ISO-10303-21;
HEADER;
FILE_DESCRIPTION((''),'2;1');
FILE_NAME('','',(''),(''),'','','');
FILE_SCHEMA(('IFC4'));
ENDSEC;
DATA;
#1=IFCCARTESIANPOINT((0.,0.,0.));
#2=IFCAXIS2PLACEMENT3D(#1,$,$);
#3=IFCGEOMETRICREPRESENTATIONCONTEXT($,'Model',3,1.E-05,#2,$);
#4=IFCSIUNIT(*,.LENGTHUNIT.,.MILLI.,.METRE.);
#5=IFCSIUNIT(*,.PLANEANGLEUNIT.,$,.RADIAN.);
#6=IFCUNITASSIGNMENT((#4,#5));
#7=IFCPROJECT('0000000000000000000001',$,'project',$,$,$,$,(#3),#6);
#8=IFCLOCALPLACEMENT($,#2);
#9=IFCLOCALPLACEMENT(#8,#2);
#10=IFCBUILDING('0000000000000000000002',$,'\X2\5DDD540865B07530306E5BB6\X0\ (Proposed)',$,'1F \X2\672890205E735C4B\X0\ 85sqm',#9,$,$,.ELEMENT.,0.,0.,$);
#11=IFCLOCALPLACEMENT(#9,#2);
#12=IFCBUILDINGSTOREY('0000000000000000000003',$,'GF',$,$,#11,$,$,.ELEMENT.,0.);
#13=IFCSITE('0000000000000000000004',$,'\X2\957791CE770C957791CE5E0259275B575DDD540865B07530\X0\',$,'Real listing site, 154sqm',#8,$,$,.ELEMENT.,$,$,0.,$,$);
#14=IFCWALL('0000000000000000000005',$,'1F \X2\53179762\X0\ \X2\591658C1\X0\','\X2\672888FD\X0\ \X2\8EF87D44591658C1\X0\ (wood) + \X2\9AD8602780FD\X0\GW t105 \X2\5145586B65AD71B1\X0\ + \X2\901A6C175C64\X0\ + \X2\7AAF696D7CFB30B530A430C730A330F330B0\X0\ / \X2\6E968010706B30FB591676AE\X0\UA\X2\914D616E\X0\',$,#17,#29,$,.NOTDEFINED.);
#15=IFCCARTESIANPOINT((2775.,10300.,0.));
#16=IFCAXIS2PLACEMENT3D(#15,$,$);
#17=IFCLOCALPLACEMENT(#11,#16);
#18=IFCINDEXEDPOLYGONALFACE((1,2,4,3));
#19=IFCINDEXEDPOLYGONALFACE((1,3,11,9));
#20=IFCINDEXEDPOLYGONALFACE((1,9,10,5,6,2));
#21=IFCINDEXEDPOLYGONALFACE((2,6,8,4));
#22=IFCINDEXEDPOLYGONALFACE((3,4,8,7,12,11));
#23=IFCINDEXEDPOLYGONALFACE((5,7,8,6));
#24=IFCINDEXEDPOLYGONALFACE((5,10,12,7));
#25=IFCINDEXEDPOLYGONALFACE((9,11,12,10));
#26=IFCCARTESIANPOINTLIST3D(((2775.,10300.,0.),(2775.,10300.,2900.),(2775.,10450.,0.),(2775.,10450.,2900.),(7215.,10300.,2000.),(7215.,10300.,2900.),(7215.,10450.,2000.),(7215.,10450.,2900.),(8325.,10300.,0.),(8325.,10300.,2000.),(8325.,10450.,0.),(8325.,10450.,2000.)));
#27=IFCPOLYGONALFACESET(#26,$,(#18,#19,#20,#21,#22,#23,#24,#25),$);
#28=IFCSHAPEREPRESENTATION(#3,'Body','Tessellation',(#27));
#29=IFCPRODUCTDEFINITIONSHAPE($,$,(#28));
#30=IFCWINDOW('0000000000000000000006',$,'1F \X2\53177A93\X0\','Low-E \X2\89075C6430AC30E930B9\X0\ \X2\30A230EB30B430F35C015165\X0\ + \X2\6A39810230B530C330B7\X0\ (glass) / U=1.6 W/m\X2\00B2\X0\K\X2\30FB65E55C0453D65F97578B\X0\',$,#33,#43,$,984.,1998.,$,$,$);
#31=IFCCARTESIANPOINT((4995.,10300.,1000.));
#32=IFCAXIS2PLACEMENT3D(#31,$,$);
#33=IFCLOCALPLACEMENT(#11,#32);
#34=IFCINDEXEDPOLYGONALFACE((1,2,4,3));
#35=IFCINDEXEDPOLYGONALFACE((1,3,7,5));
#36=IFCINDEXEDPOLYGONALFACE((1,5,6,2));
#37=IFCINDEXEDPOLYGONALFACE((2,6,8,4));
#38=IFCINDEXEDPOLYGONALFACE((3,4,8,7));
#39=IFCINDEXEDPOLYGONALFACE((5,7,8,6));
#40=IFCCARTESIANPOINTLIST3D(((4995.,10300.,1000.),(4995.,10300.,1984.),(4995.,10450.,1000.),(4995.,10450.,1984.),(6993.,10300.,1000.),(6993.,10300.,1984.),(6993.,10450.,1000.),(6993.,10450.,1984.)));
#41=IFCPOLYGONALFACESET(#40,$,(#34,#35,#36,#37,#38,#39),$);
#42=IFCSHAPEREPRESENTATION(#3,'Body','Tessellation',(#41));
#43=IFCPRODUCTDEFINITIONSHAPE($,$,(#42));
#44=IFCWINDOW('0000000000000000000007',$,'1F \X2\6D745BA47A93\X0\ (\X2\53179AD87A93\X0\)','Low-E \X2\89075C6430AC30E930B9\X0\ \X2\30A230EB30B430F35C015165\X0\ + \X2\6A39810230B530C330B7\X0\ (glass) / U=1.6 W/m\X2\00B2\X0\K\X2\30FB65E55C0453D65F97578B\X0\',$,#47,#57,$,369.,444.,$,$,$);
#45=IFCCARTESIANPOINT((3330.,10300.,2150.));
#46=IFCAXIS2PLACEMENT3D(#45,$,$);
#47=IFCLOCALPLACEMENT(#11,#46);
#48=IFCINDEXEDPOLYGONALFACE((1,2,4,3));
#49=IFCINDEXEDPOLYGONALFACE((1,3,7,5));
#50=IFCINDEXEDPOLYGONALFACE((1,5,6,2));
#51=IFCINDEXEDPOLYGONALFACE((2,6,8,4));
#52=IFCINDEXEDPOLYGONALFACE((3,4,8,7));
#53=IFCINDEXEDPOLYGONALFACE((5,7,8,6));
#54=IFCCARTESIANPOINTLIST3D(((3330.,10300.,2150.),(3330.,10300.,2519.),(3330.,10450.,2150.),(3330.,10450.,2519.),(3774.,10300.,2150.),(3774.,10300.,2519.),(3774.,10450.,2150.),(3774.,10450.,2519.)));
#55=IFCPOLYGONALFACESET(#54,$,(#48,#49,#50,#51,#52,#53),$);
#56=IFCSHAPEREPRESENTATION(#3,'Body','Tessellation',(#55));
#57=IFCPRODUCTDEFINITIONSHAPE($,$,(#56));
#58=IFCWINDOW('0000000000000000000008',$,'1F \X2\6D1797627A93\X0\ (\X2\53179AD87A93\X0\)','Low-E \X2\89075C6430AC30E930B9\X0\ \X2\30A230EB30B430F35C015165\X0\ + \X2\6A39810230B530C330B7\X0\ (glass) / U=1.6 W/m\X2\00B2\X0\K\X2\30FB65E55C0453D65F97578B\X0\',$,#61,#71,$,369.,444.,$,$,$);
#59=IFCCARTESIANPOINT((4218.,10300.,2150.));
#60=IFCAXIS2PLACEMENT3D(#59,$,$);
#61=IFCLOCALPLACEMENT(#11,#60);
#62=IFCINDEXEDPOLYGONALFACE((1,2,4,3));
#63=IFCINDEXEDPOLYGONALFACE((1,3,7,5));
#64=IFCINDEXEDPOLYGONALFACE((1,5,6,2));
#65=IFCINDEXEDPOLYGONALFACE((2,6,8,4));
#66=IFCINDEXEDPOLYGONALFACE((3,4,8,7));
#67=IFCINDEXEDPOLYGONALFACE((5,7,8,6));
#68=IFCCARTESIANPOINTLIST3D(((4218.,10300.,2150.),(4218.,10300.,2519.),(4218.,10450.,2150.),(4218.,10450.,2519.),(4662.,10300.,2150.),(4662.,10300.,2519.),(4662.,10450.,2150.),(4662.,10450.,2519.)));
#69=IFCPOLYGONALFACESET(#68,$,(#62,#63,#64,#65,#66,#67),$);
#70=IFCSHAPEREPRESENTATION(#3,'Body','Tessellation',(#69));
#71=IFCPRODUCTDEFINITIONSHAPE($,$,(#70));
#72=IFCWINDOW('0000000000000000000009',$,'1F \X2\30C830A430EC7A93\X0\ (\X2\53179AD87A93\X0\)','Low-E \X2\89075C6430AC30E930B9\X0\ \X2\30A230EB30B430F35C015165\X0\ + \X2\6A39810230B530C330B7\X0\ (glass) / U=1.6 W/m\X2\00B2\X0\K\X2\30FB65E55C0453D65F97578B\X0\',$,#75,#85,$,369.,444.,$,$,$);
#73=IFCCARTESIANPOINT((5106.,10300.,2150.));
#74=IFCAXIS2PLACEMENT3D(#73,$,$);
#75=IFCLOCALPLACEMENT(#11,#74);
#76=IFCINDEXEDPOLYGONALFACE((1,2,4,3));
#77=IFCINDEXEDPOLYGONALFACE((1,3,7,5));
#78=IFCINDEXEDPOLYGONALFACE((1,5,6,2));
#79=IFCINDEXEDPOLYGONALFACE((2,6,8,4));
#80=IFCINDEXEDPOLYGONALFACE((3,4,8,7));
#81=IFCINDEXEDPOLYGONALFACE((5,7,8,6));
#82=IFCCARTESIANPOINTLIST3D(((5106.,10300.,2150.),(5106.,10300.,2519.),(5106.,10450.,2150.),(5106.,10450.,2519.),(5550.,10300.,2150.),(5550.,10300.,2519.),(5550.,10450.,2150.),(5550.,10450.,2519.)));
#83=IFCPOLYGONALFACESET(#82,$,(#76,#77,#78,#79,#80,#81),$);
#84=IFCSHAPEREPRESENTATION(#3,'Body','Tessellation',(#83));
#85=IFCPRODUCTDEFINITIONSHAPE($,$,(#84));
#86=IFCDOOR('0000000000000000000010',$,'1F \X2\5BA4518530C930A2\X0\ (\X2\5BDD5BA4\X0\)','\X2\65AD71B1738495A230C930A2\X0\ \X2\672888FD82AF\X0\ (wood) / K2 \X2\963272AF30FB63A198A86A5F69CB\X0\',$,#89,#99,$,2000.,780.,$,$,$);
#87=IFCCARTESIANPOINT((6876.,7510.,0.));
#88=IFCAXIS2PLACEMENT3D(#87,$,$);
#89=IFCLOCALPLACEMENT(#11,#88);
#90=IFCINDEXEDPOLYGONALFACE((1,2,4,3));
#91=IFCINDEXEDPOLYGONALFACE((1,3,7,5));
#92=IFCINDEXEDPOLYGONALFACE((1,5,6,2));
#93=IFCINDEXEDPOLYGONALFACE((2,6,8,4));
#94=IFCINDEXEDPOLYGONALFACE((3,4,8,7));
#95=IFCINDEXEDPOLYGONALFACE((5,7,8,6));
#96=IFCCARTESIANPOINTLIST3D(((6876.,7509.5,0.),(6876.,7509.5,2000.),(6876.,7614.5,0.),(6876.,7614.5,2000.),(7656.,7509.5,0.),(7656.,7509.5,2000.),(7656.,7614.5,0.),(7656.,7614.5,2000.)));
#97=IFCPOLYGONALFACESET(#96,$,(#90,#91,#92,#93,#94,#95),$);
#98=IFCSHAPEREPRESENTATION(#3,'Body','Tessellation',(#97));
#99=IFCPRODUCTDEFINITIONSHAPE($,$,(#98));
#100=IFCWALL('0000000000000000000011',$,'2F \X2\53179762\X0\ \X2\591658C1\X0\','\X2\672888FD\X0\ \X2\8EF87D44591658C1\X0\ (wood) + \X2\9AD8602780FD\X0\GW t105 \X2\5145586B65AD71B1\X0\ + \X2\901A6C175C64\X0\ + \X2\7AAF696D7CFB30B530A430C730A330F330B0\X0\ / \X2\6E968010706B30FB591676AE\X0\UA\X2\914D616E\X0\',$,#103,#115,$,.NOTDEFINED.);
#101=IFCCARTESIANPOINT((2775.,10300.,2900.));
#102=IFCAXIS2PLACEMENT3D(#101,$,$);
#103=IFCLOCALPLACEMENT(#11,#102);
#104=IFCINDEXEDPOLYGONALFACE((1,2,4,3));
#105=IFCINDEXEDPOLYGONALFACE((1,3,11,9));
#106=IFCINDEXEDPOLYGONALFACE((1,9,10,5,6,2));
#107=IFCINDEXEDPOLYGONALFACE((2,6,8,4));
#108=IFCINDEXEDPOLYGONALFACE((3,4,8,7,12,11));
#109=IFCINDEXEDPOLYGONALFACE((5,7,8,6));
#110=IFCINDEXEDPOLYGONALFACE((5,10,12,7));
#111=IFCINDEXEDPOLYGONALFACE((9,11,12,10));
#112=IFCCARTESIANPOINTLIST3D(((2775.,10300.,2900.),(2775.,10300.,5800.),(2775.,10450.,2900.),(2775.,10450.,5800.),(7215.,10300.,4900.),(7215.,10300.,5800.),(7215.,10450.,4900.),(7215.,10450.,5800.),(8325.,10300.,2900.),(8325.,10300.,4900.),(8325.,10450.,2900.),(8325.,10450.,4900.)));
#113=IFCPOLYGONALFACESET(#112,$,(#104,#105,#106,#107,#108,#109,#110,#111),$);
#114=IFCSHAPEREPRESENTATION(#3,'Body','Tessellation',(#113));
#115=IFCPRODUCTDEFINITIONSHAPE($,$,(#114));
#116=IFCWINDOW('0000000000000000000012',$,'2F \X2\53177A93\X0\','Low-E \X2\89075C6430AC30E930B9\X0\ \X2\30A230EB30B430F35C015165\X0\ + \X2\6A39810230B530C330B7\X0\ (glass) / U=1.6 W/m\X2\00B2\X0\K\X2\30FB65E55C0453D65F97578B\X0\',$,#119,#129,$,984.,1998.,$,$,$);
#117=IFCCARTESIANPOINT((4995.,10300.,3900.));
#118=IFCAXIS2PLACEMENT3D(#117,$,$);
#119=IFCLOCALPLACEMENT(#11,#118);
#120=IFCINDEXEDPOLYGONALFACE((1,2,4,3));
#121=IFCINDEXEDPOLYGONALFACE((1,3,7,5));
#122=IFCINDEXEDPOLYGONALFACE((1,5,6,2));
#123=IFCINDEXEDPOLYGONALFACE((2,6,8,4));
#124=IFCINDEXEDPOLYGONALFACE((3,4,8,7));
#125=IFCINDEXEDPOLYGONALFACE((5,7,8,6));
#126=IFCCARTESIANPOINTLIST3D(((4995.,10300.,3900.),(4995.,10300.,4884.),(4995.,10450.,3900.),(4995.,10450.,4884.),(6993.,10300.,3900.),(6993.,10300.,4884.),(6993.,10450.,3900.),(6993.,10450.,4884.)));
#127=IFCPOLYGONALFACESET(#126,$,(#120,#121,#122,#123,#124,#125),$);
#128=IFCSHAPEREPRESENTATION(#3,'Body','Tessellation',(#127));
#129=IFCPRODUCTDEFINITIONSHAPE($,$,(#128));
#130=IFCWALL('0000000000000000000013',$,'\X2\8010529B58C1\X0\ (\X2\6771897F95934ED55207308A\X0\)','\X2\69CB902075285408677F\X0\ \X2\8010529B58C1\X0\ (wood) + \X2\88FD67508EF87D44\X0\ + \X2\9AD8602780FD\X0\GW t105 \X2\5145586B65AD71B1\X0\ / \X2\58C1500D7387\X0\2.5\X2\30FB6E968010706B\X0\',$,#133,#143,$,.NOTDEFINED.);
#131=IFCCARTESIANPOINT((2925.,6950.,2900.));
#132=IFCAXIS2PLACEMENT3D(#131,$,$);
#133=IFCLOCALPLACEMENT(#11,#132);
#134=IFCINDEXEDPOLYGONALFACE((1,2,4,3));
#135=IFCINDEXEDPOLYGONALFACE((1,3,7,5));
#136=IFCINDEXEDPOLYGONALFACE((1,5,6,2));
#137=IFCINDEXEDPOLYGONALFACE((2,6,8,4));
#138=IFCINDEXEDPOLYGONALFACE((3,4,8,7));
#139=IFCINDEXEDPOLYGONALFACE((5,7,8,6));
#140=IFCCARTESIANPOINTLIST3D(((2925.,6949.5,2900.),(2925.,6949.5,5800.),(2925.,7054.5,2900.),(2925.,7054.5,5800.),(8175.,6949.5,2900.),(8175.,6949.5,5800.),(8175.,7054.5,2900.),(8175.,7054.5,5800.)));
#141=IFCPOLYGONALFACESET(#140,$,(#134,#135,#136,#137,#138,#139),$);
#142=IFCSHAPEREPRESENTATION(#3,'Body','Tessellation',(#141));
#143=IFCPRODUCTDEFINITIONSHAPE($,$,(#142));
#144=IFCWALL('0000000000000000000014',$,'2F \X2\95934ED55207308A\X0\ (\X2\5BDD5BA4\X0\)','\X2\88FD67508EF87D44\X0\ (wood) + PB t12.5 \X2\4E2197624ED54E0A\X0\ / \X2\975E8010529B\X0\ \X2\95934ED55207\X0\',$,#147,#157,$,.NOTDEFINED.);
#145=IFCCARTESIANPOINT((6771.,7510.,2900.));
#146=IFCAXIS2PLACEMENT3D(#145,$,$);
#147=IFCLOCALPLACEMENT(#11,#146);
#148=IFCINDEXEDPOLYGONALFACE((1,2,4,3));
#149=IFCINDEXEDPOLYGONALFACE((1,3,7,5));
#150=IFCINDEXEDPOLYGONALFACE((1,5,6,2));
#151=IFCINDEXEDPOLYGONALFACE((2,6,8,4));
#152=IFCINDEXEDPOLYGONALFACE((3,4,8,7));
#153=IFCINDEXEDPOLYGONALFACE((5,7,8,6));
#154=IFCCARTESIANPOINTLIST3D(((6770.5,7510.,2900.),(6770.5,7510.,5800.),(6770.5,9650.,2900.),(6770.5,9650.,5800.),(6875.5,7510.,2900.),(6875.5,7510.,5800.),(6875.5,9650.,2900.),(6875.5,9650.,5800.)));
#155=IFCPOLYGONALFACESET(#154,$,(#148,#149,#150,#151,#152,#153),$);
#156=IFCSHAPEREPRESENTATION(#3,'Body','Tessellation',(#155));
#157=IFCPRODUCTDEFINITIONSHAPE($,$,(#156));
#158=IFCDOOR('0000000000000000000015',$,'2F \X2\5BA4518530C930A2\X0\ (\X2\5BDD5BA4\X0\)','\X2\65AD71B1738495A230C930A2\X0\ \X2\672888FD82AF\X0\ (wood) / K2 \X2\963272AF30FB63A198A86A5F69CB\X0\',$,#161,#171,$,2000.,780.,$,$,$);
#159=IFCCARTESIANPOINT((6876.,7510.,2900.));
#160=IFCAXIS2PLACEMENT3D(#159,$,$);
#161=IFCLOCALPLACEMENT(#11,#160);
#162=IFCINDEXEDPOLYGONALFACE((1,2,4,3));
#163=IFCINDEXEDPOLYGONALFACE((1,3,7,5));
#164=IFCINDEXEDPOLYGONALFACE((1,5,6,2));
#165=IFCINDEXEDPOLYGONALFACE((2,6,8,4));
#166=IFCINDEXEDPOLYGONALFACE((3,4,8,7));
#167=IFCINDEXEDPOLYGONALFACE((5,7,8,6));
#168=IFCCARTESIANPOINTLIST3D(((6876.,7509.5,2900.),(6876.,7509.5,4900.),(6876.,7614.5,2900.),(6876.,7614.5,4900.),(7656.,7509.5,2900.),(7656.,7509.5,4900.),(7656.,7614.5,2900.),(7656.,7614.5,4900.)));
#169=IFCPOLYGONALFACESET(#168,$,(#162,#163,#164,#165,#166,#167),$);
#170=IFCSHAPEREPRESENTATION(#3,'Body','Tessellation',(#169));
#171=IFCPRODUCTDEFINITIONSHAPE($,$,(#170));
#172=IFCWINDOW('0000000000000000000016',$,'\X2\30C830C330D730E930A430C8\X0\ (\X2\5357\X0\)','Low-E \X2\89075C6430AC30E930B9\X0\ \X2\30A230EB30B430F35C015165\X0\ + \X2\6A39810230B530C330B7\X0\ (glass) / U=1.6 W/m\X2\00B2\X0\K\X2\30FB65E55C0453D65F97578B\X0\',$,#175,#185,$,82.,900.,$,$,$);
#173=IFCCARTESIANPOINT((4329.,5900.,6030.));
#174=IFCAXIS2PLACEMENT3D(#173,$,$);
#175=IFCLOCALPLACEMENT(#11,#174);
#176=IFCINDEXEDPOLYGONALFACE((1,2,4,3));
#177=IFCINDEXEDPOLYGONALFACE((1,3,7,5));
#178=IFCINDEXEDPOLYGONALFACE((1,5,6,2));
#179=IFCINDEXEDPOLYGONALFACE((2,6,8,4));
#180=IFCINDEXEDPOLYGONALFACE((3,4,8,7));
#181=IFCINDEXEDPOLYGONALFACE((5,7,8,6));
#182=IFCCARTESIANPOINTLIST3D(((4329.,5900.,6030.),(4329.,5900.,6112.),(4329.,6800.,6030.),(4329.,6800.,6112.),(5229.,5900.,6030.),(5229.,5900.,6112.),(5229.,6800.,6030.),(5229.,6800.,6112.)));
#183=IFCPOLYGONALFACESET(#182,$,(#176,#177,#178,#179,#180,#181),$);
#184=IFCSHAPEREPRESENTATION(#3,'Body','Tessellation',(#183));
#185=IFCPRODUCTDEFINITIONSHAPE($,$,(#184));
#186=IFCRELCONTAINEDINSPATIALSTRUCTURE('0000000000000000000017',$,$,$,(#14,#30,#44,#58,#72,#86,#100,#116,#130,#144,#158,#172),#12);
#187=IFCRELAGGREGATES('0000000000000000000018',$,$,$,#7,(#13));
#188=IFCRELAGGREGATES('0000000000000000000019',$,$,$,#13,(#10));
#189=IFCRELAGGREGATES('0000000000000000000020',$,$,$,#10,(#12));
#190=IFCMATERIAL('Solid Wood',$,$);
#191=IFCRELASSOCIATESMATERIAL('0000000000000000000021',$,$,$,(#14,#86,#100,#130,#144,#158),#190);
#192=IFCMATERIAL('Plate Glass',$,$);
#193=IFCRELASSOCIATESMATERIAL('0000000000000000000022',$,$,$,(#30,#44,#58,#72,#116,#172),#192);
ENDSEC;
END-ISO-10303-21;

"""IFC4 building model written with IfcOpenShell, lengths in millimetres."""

from ifc_helpers import new_model, si_unit, frame, frame_2d, origin, place, context, project, spatial, rectangle, extrude, material, element, fill, save


model = new_model("IFC4")

# Units and contexts
model_context = context("Model", 3, precision=1e-05, world=origin())
ifc_project = project(units=[si_unit("LENGTHUNIT", "METRE", prefix="MILLI"), si_unit("PLANEANGLEUNIT", "RADIAN")], contexts=[model_context])

# Site, building, storey
site_placement = place(None, origin())
site = spatial("IfcSite", under=ifc_project, at=site_placement, Name="長野県長野市大字川合新田", ObjectType="Real listing site, 154sqm", CompositionType="ELEMENT", RefElevation=0.0)
building_placement = place(site_placement, origin())
building = spatial("IfcBuilding", under=site, at=building_placement, Name="川合新田の家 (Proposed)", ObjectType="1F 木造平屋 85sqm", CompositionType="ELEMENT", ElevationOfRefHeight=0.0, ElevationOfTerrain=0.0)
storey_placement = place(building_placement, origin())
storey = spatial("IfcBuildingStorey", under=building, at=storey_placement, Name="GF", CompositionType="ELEMENT", Elevation=0.0)

# Wall, openings, windows
ifc_material_1 = material(Name="Solid Wood")
wall_1_placement = place(storey_placement, frame((2775.0, 10300.0, 0.0)))
wall_1 = element("IfcWall", 1, at=wall_1_placement, inside=storey, material=ifc_material_1, Name="1F 北面 外壁", Description="木製 軸組外壁 (wood) + 高性能GW t105 充填断熱 + 通気層 + 窯業系サイディング / 準耐火・外皮UA配慮", PredefinedType="NOTDEFINED", context=model_context, shape_type="SweptSolid", body=[
    extrude(rectangle(XDim=5550.0, YDim=150.0, at=frame_2d((2775.0, 75.0))), frame((2775.0, 10300.0, 0.0)), (0.0, 0.0, 1.0), 2900.0),
])
opening_1_placement = place(storey_placement, frame((4995.0, 10300.0, 1000.0)))
opening_1 = element("IfcOpeningElement", 2, at=opening_1_placement, cuts=wall_1, PredefinedType="NOTDEFINED", context=model_context, shape_type="SweptSolid", body=[
    extrude(rectangle(XDim=1998.0, YDim=150.0, at=frame_2d((999.0, 75.0))), frame((4995.0, 10300.0, 1000.0)), (0.0, 0.0, 1.0), 984.0),
])
opening_2_placement = place(storey_placement, frame((3330.0, 10300.0, 2150.0)))
opening_2 = element("IfcOpeningElement", 3, at=opening_2_placement, cuts=wall_1, PredefinedType="NOTDEFINED", context=model_context, shape_type="SweptSolid", body=[
    extrude(rectangle(XDim=444.0, YDim=150.0, at=frame_2d((222.0, 75.0))), frame((3330.0, 10300.0, 2150.0)), (0.0, 0.0, 1.0), 369.0),
])
opening_3_placement = place(storey_placement, frame((4218.0, 10300.0, 2150.0)))
opening_3 = element("IfcOpeningElement", 4, at=opening_3_placement, cuts=wall_1, PredefinedType="NOTDEFINED", context=model_context, shape_type="SweptSolid", body=[
    extrude(rectangle(XDim=444.0, YDim=150.0, at=frame_2d((222.0, 75.0))), frame((4218.0, 10300.0, 2150.0)), (0.0, 0.0, 1.0), 369.0),
])
opening_4_placement = place(storey_placement, frame((5106.0, 10300.0, 2150.0)))
opening_4 = element("IfcOpeningElement", 5, at=opening_4_placement, cuts=wall_1, PredefinedType="NOTDEFINED", context=model_context, shape_type="SweptSolid", body=[
    extrude(rectangle(XDim=444.0, YDim=150.0, at=frame_2d((222.0, 75.0))), frame((5106.0, 10300.0, 2150.0)), (0.0, 0.0, 1.0), 369.0),
])
ifc_material_2 = material(Name="Plate Glass")
window_1_placement = place(storey_placement, frame((4995.0, 10300.0, 1000.0)))
window_1 = element("IfcWindow", 6, at=window_1_placement, inside=storey, material=ifc_material_2, Name="1F 北窓", Description="Low-E 複層ガラス アルゴン封入 + 樹脂サッシ (glass) / U=1.6 W/m²K・日射取得型", OverallHeight=984.0, OverallWidth=1998.0, context=model_context, shape_type="SweptSolid", body=[
    extrude(rectangle(XDim=1998.0, YDim=150.0, at=frame_2d((999.0, 75.0))), frame((4995.0, 10300.0, 1000.0)), (0.0, 0.0, 1.0), 984.0),
])
fill(opening_1, window_1)
window_2_placement = place(storey_placement, frame((3330.0, 10300.0, 2150.0)))
window_2 = element("IfcWindow", 7, at=window_2_placement, inside=storey, material=ifc_material_2, Name="1F 浴室窓 (北高窓)", Description="Low-E 複層ガラス アルゴン封入 + 樹脂サッシ (glass) / U=1.6 W/m²K・日射取得型", OverallHeight=369.0, OverallWidth=444.0, context=model_context, shape_type="SweptSolid", body=[
    extrude(rectangle(XDim=444.0, YDim=150.0, at=frame_2d((222.0, 75.0))), frame((3330.0, 10300.0, 2150.0)), (0.0, 0.0, 1.0), 369.0),
])
fill(opening_2, window_2)
window_3_placement = place(storey_placement, frame((4218.0, 10300.0, 2150.0)))
window_3 = element("IfcWindow", 8, at=window_3_placement, inside=storey, material=ifc_material_2, Name="1F 洗面窓 (北高窓)", Description="Low-E 複層ガラス アルゴン封入 + 樹脂サッシ (glass) / U=1.6 W/m²K・日射取得型", OverallHeight=369.0, OverallWidth=444.0, context=model_context, shape_type="SweptSolid", body=[
    extrude(rectangle(XDim=444.0, YDim=150.0, at=frame_2d((222.0, 75.0))), frame((4218.0, 10300.0, 2150.0)), (0.0, 0.0, 1.0), 369.0),
])
fill(opening_3, window_3)
window_4_placement = place(storey_placement, frame((5106.0, 10300.0, 2150.0)))
window_4 = element("IfcWindow", 9, at=window_4_placement, inside=storey, material=ifc_material_2, Name="1F トイレ窓 (北高窓)", Description="Low-E 複層ガラス アルゴン封入 + 樹脂サッシ (glass) / U=1.6 W/m²K・日射取得型", OverallHeight=369.0, OverallWidth=444.0, context=model_context, shape_type="SweptSolid", body=[
    extrude(rectangle(XDim=444.0, YDim=150.0, at=frame_2d((222.0, 75.0))), frame((5106.0, 10300.0, 2150.0)), (0.0, 0.0, 1.0), 369.0),
])
fill(opening_4, window_4)

# Door
door_1_placement = place(storey_placement, frame((6876.0, 7510.0, 0.0)))
element("IfcDoor", 10, at=door_1_placement, inside=storey, material=ifc_material_1, Name="1F 室内ドア (寝室)", Description="断熱玄関ドア 木製芯 (wood) / K2 防犯・採風機構", OverallHeight=2000.0, OverallWidth=780.0, context=model_context, shape_type="SweptSolid", body=[
    extrude(rectangle(XDim=780.0, YDim=105.0, at=frame_2d((390.0, 52.0))), frame((6876.0, 7510.0, 0.0)), (0.0, 0.0, 1.0), 2000.0),
])

# Wall, opening, window
wall_2_placement = place(storey_placement, frame((2775.0, 10300.0, 2900.0)))
wall_2 = element("IfcWall", 11, at=wall_2_placement, inside=storey, material=ifc_material_1, Name="2F 北面 外壁", Description="木製 軸組外壁 (wood) + 高性能GW t105 充填断熱 + 通気層 + 窯業系サイディング / 準耐火・外皮UA配慮", PredefinedType="NOTDEFINED", context=model_context, shape_type="SweptSolid", body=[
    extrude(rectangle(XDim=5550.0, YDim=150.0, at=frame_2d((2775.0, 75.0))), frame((2775.0, 10300.0, 2900.0)), (0.0, 0.0, 1.0), 2900.0),
])
opening_5_placement = place(storey_placement, frame((4995.0, 10300.0, 3900.0)))
opening_5 = element("IfcOpeningElement", 12, at=opening_5_placement, cuts=wall_2, PredefinedType="NOTDEFINED", context=model_context, shape_type="SweptSolid", body=[
    extrude(rectangle(XDim=1998.0, YDim=150.0, at=frame_2d((999.0, 75.0))), frame((4995.0, 10300.0, 3900.0)), (0.0, 0.0, 1.0), 984.0),
])
window_5_placement = place(storey_placement, frame((4995.0, 10300.0, 3900.0)))
window_5 = element("IfcWindow", 13, at=window_5_placement, inside=storey, material=ifc_material_2, Name="2F 北窓", Description="Low-E 複層ガラス アルゴン封入 + 樹脂サッシ (glass) / U=1.6 W/m²K・日射取得型", OverallHeight=984.0, OverallWidth=1998.0, context=model_context, shape_type="SweptSolid", body=[
    extrude(rectangle(XDim=1998.0, YDim=150.0, at=frame_2d((999.0, 75.0))), frame((4995.0, 10300.0, 3900.0)), (0.0, 0.0, 1.0), 984.0),
])
fill(opening_5, window_5)

# Walls
wall_3_placement = place(storey_placement, frame((2925.0, 6950.0, 2900.0)))
element("IfcWall", 14, at=wall_3_placement, inside=storey, material=ifc_material_1, Name="耐力壁 (東西間仕切り)", Description="構造用合板 耐力壁 (wood) + 製材軸組 + 高性能GW t105 充填断熱 / 壁倍率2.5・準耐火", PredefinedType="NOTDEFINED", context=model_context, shape_type="SweptSolid", body=[
    extrude(rectangle(XDim=5250.0, YDim=105.0, at=frame_2d((2625.0, 52.0))), frame((2925.0, 6950.0, 2900.0)), (0.0, 0.0, 1.0), 2900.0),
])
wall_4_placement = place(storey_placement, frame((6771.0, 7510.0, 2900.0)))
element("IfcWall", 15, at=wall_4_placement, inside=storey, material=ifc_material_1, Name="2F 間仕切り (寝室)", Description="製材軸組 (wood) + PB t12.5 両面仕上 / 非耐力 間仕切", PredefinedType="NOTDEFINED", context=model_context, shape_type="SweptSolid", body=[
    extrude(rectangle(XDim=105.0, YDim=2140.0, at=frame_2d((52.0, 1070.0))), frame((6771.0, 7510.0, 2900.0)), (0.0, 0.0, 1.0), 2900.0),
])

# Door
door_2_placement = place(storey_placement, frame((6876.0, 7510.0, 2900.0)))
element("IfcDoor", 16, at=door_2_placement, inside=storey, material=ifc_material_1, Name="2F 室内ドア (寝室)", Description="断熱玄関ドア 木製芯 (wood) / K2 防犯・採風機構", OverallHeight=2000.0, OverallWidth=780.0, context=model_context, shape_type="SweptSolid", body=[
    extrude(rectangle(XDim=780.0, YDim=105.0, at=frame_2d((390.0, 52.0))), frame((6876.0, 7510.0, 2900.0)), (0.0, 0.0, 1.0), 2000.0),
])

# Window
window_6_placement = place(storey_placement, frame((4329.0, 5900.0, 6030.0)))
element("IfcWindow", 17, at=window_6_placement, inside=storey, material=ifc_material_2, Name="トップライト (南)", Description="Low-E 複層ガラス アルゴン封入 + 樹脂サッシ (glass) / U=1.6 W/m²K・日射取得型", OverallHeight=82.0, OverallWidth=900.0, context=model_context, shape_type="SweptSolid", body=[
    extrude(rectangle(XDim=900.0, YDim=900.0, at=frame_2d((450.0, 450.0))), frame((4329.0, 5900.0, 6030.0)), (0.0, 0.0, 1.0), 82.0),
])

save(model, "model.ifc")
